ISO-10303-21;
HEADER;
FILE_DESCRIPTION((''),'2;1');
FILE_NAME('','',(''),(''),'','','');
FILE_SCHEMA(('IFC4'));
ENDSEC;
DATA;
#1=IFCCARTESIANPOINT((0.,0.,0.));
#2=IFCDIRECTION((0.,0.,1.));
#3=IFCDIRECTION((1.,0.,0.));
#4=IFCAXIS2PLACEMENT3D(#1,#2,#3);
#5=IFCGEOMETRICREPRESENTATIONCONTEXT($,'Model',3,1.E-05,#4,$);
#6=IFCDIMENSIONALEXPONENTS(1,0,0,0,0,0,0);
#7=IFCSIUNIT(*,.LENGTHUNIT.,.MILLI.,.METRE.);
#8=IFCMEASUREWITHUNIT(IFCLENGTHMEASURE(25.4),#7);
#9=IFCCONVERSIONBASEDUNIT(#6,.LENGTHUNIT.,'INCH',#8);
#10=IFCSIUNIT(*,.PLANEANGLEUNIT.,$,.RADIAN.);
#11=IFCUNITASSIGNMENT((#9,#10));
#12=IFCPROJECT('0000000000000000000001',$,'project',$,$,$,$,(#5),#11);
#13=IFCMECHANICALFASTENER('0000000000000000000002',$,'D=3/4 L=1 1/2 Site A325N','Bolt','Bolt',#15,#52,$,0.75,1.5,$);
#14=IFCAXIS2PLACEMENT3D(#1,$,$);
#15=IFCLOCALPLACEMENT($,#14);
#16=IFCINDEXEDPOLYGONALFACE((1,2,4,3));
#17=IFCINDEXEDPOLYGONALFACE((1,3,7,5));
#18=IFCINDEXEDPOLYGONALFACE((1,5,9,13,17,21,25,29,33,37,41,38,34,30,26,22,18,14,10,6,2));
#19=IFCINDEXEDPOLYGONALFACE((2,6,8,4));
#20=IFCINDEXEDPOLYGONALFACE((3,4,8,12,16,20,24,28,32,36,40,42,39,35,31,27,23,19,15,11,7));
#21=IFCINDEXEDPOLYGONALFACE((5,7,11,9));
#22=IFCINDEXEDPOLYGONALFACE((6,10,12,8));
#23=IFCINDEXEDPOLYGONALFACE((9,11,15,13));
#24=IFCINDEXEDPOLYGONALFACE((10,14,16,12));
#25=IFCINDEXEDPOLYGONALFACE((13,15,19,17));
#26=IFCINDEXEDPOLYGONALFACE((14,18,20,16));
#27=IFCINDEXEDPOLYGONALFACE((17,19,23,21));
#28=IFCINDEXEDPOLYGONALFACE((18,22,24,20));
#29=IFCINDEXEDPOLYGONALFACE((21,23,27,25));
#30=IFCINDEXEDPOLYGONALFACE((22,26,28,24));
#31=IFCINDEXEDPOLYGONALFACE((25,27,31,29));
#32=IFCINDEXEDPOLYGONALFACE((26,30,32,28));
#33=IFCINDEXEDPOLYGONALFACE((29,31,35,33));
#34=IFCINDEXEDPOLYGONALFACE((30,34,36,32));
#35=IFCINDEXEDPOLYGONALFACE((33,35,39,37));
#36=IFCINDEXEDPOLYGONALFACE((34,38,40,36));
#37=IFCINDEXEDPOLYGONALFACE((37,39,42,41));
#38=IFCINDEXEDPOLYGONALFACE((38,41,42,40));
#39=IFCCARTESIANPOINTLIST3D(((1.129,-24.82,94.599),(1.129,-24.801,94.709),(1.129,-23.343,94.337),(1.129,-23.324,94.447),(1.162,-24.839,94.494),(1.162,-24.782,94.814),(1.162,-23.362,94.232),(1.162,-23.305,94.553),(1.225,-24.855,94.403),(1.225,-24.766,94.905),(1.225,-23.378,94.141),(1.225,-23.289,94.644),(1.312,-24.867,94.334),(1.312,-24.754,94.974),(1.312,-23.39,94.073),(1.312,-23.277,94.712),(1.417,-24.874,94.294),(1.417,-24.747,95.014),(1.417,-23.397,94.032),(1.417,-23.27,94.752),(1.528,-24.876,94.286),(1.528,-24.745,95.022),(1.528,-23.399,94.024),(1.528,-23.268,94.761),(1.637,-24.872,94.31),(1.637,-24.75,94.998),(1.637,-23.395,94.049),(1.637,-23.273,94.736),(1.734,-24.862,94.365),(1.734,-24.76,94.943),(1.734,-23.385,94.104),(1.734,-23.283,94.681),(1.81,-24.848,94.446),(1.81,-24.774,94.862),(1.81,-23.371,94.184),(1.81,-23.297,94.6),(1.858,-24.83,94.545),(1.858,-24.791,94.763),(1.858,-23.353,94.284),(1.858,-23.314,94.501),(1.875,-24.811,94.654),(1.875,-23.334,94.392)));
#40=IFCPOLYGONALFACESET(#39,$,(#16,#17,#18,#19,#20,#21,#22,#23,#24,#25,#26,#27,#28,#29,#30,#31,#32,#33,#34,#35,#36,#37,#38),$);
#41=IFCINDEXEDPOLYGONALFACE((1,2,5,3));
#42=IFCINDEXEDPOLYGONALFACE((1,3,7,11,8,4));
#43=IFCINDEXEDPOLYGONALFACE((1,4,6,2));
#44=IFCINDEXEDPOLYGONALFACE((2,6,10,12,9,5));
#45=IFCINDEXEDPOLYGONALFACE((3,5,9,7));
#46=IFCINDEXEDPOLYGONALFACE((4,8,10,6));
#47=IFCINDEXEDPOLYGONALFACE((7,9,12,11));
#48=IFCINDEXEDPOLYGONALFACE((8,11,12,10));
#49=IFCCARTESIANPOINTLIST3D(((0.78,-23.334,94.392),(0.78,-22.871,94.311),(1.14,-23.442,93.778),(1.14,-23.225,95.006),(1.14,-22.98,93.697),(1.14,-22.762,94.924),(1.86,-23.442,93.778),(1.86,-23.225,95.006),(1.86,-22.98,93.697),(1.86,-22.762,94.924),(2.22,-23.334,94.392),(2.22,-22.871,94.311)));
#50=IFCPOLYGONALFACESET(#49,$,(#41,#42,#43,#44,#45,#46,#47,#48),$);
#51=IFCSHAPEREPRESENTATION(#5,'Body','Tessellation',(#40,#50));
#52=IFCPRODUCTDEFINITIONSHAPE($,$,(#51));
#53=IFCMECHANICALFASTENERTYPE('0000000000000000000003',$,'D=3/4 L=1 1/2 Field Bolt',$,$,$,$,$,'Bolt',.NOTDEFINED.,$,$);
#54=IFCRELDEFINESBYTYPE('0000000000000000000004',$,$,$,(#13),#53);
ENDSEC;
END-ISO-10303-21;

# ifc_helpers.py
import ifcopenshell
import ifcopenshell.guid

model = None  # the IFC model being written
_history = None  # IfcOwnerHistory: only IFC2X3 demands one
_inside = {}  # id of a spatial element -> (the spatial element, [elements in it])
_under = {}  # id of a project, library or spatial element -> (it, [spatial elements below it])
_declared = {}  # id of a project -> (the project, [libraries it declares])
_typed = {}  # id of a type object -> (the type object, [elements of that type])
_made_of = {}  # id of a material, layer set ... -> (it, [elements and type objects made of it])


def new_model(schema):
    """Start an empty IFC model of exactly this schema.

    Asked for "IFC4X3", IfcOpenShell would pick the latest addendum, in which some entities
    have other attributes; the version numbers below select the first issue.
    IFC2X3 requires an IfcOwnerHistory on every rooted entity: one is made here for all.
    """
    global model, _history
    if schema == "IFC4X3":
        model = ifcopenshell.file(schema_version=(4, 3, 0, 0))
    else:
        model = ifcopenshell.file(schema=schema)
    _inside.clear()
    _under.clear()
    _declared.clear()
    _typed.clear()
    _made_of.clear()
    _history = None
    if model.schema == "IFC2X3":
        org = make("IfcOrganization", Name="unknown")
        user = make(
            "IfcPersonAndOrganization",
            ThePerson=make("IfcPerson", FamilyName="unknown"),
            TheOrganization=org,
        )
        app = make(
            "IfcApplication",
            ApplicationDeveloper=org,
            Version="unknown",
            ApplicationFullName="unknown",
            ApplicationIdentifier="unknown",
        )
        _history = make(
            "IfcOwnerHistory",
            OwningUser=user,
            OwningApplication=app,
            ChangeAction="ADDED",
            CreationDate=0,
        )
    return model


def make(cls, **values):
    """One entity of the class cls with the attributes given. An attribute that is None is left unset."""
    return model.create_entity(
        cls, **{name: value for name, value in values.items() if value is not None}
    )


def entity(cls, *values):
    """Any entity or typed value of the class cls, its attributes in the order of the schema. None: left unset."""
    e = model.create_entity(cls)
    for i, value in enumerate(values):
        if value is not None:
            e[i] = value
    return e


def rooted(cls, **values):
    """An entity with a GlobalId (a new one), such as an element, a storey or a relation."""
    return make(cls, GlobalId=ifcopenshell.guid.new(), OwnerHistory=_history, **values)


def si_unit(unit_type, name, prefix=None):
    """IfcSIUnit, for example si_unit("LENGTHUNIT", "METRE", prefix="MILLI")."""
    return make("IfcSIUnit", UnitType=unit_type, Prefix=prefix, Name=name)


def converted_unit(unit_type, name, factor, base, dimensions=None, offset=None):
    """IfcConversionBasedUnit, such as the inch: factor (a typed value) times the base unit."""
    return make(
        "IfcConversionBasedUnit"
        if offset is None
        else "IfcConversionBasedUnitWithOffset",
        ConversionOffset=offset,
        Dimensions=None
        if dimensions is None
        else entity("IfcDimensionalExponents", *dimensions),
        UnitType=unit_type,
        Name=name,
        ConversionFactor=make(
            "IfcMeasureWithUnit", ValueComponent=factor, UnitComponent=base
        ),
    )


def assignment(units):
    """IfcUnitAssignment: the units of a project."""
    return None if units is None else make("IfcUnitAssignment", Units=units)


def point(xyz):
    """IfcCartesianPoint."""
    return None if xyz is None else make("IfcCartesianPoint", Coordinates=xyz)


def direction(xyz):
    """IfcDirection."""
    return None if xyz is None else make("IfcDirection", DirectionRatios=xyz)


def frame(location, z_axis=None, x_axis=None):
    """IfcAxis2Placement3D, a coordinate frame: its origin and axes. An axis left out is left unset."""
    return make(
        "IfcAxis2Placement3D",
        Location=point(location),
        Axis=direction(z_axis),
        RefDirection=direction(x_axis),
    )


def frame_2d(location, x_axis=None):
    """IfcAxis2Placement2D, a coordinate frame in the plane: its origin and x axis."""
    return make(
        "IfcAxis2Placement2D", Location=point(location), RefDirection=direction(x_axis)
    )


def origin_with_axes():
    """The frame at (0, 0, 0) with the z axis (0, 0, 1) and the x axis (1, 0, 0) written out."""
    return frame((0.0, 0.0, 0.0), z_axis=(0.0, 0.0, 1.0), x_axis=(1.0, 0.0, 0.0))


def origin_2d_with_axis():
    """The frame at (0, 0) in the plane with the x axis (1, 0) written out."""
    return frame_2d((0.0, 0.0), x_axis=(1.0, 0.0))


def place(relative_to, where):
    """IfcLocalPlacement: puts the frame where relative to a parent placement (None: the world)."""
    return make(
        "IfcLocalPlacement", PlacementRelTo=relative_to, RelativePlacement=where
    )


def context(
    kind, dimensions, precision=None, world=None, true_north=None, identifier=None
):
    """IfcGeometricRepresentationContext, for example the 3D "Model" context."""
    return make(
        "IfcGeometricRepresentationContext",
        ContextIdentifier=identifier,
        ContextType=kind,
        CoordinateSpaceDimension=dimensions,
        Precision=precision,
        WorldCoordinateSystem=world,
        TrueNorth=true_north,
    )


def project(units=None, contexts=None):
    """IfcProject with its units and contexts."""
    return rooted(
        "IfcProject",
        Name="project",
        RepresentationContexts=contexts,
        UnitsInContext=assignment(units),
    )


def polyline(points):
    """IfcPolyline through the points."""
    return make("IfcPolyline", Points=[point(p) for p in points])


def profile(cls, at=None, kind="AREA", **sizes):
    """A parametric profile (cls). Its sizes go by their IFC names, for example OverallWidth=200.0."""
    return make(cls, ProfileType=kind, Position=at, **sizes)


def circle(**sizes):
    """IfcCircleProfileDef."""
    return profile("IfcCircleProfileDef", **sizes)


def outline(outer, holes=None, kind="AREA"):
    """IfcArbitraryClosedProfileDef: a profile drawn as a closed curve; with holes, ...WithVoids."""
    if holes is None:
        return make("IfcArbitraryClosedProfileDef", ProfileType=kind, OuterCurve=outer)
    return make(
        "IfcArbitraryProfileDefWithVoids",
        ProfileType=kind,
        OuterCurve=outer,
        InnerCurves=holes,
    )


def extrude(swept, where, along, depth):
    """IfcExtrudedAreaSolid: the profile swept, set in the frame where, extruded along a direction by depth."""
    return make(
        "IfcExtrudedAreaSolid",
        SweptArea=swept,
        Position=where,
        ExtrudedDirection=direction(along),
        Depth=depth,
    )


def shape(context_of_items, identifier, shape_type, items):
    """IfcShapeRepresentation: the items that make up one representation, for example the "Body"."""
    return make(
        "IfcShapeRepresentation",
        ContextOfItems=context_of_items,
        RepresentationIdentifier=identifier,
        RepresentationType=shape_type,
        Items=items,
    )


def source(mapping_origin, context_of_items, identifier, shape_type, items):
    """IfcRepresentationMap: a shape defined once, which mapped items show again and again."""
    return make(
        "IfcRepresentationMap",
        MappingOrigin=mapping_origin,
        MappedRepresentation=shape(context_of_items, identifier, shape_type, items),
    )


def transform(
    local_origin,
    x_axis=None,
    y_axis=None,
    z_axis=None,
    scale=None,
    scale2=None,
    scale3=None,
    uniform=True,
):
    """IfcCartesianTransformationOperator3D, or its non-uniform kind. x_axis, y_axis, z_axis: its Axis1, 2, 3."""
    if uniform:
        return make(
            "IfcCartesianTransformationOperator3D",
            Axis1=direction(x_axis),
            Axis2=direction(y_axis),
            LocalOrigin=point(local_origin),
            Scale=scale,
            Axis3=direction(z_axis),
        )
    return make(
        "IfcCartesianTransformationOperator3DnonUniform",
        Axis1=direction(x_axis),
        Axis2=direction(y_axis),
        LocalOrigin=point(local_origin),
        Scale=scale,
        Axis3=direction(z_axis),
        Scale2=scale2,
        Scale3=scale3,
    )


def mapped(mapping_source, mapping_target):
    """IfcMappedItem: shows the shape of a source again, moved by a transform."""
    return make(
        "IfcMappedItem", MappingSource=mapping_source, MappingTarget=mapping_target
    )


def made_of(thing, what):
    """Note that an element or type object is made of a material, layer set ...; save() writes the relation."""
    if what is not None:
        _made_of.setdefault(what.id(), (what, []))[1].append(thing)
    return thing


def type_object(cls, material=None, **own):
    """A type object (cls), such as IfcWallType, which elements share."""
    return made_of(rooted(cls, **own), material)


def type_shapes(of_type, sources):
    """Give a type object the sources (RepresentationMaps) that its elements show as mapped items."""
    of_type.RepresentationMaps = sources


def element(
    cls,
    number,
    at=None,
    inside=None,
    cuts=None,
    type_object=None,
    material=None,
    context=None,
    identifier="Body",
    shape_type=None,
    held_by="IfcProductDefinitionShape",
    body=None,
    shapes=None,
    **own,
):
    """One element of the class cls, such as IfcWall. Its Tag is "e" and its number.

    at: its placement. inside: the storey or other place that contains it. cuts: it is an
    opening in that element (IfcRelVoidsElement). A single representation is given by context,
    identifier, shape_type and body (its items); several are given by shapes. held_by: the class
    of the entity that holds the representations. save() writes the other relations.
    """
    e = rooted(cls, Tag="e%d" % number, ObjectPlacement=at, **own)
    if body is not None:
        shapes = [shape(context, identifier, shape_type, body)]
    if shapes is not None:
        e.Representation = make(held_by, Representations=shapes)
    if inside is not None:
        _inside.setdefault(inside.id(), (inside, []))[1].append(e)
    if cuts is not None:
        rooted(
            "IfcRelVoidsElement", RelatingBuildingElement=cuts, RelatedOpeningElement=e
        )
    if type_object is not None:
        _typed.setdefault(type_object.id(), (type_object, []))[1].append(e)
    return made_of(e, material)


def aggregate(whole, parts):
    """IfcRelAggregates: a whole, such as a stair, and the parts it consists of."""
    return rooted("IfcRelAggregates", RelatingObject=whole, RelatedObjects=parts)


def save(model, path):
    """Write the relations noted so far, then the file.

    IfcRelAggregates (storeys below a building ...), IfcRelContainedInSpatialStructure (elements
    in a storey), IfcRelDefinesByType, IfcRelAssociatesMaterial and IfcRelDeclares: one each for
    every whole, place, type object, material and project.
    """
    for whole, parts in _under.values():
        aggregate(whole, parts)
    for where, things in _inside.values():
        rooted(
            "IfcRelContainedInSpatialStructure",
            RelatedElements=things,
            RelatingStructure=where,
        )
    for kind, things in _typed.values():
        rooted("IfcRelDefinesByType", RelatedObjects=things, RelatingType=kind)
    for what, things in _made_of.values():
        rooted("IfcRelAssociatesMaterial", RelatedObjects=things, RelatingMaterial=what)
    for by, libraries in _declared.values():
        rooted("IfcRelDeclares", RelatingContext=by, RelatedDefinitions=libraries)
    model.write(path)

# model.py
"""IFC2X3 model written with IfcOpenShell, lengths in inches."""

from ifc_helpers import new_model, entity, si_unit, converted_unit, frame, origin_with_axes, origin_2d_with_axis, place, context, project, polyline, circle, outline, extrude, source, transform, mapped, type_object, type_shapes, element, save


model = new_model("IFC2X3")

# Units and contexts
model_context = context("Model", 3, precision=1e-05, world=origin_with_axes())
ifc_project = project(units=[converted_unit("LENGTHUNIT", "INCH", entity("IfcLengthMeasure", 25.4), si_unit("LENGTHUNIT", "METRE", prefix="MILLI"), dimensions=[1, 0, 0, 0, 0, 0, 0]), si_unit("PLANEANGLEUNIT", "RADIAN")], contexts=[model_context])

# Mechanical fastener
placement_1 = place(None, origin_with_axes())
placement_2 = place(placement_1, origin_with_axes())
placement_3 = place(placement_2, frame((0.0, -48.0, 94.0), z_axis=(0.0, 0.17437, 0.98468), x_axis=(0.0, 0.98468, -0.17437)))
mechanical_fastener_type_1 = type_object("IfcMechanicalFastenerType", Name="D=3/4 L=1 1/2 Field Bolt", ElementType="Bolt")
shared_shape_1 = source(origin_with_axes(), model_context, "Body", "SweptSolid", [
    extrude(circle(Radius=0.375, at=origin_2d_with_axis()), frame((0.0, 0.0, 0.0), z_axis=(1.0, 0.0, 0.0), x_axis=(0.0, 1.0, 0.0)), (0.0, 0.0, 1.0), 1.5),
    extrude(outline(polyline([(-0.72, 0.0), (-0.36, 0.624), (0.36, 0.624), (0.72, 0.0), (0.36, -0.624), (-0.36, -0.624), (-0.72, 0.0)])), frame((0.0, 0.0, 0.0), z_axis=(1.0, 0.0, 0.0), x_axis=(0.0, 1.0, 0.0)), (0.0, 0.0, -1.0), 0.47),
])
type_shapes(mechanical_fastener_type_1, [shared_shape_1])
placement_4 = place(placement_3, frame((24.22, 1.5, 4.688), z_axis=(0.0, 0.0, 1.0), x_axis=(-1.0, 0.0, 0.0)))
mechanical_fastener_1_placement = place(placement_4, frame((0.0, 3.0, 0.0), z_axis=(0.0, 0.0, 1.0), x_axis=(1.0, 0.0, 0.0)))
element("IfcMechanicalFastener", 1, at=mechanical_fastener_1_placement, type_object=mechanical_fastener_type_1, Name="D=3/4 L=1 1/2 Site A325N", Description="Bolt", ObjectType="Bolt", NominalDiameter=0.75, NominalLength=1.5, context=model_context, shape_type="MappedRepresentation", body=[
    mapped(shared_shape_1, transform((0.0, 0.0, 0.0), scale=1.0)),
])

save(model, "model.ifc")
